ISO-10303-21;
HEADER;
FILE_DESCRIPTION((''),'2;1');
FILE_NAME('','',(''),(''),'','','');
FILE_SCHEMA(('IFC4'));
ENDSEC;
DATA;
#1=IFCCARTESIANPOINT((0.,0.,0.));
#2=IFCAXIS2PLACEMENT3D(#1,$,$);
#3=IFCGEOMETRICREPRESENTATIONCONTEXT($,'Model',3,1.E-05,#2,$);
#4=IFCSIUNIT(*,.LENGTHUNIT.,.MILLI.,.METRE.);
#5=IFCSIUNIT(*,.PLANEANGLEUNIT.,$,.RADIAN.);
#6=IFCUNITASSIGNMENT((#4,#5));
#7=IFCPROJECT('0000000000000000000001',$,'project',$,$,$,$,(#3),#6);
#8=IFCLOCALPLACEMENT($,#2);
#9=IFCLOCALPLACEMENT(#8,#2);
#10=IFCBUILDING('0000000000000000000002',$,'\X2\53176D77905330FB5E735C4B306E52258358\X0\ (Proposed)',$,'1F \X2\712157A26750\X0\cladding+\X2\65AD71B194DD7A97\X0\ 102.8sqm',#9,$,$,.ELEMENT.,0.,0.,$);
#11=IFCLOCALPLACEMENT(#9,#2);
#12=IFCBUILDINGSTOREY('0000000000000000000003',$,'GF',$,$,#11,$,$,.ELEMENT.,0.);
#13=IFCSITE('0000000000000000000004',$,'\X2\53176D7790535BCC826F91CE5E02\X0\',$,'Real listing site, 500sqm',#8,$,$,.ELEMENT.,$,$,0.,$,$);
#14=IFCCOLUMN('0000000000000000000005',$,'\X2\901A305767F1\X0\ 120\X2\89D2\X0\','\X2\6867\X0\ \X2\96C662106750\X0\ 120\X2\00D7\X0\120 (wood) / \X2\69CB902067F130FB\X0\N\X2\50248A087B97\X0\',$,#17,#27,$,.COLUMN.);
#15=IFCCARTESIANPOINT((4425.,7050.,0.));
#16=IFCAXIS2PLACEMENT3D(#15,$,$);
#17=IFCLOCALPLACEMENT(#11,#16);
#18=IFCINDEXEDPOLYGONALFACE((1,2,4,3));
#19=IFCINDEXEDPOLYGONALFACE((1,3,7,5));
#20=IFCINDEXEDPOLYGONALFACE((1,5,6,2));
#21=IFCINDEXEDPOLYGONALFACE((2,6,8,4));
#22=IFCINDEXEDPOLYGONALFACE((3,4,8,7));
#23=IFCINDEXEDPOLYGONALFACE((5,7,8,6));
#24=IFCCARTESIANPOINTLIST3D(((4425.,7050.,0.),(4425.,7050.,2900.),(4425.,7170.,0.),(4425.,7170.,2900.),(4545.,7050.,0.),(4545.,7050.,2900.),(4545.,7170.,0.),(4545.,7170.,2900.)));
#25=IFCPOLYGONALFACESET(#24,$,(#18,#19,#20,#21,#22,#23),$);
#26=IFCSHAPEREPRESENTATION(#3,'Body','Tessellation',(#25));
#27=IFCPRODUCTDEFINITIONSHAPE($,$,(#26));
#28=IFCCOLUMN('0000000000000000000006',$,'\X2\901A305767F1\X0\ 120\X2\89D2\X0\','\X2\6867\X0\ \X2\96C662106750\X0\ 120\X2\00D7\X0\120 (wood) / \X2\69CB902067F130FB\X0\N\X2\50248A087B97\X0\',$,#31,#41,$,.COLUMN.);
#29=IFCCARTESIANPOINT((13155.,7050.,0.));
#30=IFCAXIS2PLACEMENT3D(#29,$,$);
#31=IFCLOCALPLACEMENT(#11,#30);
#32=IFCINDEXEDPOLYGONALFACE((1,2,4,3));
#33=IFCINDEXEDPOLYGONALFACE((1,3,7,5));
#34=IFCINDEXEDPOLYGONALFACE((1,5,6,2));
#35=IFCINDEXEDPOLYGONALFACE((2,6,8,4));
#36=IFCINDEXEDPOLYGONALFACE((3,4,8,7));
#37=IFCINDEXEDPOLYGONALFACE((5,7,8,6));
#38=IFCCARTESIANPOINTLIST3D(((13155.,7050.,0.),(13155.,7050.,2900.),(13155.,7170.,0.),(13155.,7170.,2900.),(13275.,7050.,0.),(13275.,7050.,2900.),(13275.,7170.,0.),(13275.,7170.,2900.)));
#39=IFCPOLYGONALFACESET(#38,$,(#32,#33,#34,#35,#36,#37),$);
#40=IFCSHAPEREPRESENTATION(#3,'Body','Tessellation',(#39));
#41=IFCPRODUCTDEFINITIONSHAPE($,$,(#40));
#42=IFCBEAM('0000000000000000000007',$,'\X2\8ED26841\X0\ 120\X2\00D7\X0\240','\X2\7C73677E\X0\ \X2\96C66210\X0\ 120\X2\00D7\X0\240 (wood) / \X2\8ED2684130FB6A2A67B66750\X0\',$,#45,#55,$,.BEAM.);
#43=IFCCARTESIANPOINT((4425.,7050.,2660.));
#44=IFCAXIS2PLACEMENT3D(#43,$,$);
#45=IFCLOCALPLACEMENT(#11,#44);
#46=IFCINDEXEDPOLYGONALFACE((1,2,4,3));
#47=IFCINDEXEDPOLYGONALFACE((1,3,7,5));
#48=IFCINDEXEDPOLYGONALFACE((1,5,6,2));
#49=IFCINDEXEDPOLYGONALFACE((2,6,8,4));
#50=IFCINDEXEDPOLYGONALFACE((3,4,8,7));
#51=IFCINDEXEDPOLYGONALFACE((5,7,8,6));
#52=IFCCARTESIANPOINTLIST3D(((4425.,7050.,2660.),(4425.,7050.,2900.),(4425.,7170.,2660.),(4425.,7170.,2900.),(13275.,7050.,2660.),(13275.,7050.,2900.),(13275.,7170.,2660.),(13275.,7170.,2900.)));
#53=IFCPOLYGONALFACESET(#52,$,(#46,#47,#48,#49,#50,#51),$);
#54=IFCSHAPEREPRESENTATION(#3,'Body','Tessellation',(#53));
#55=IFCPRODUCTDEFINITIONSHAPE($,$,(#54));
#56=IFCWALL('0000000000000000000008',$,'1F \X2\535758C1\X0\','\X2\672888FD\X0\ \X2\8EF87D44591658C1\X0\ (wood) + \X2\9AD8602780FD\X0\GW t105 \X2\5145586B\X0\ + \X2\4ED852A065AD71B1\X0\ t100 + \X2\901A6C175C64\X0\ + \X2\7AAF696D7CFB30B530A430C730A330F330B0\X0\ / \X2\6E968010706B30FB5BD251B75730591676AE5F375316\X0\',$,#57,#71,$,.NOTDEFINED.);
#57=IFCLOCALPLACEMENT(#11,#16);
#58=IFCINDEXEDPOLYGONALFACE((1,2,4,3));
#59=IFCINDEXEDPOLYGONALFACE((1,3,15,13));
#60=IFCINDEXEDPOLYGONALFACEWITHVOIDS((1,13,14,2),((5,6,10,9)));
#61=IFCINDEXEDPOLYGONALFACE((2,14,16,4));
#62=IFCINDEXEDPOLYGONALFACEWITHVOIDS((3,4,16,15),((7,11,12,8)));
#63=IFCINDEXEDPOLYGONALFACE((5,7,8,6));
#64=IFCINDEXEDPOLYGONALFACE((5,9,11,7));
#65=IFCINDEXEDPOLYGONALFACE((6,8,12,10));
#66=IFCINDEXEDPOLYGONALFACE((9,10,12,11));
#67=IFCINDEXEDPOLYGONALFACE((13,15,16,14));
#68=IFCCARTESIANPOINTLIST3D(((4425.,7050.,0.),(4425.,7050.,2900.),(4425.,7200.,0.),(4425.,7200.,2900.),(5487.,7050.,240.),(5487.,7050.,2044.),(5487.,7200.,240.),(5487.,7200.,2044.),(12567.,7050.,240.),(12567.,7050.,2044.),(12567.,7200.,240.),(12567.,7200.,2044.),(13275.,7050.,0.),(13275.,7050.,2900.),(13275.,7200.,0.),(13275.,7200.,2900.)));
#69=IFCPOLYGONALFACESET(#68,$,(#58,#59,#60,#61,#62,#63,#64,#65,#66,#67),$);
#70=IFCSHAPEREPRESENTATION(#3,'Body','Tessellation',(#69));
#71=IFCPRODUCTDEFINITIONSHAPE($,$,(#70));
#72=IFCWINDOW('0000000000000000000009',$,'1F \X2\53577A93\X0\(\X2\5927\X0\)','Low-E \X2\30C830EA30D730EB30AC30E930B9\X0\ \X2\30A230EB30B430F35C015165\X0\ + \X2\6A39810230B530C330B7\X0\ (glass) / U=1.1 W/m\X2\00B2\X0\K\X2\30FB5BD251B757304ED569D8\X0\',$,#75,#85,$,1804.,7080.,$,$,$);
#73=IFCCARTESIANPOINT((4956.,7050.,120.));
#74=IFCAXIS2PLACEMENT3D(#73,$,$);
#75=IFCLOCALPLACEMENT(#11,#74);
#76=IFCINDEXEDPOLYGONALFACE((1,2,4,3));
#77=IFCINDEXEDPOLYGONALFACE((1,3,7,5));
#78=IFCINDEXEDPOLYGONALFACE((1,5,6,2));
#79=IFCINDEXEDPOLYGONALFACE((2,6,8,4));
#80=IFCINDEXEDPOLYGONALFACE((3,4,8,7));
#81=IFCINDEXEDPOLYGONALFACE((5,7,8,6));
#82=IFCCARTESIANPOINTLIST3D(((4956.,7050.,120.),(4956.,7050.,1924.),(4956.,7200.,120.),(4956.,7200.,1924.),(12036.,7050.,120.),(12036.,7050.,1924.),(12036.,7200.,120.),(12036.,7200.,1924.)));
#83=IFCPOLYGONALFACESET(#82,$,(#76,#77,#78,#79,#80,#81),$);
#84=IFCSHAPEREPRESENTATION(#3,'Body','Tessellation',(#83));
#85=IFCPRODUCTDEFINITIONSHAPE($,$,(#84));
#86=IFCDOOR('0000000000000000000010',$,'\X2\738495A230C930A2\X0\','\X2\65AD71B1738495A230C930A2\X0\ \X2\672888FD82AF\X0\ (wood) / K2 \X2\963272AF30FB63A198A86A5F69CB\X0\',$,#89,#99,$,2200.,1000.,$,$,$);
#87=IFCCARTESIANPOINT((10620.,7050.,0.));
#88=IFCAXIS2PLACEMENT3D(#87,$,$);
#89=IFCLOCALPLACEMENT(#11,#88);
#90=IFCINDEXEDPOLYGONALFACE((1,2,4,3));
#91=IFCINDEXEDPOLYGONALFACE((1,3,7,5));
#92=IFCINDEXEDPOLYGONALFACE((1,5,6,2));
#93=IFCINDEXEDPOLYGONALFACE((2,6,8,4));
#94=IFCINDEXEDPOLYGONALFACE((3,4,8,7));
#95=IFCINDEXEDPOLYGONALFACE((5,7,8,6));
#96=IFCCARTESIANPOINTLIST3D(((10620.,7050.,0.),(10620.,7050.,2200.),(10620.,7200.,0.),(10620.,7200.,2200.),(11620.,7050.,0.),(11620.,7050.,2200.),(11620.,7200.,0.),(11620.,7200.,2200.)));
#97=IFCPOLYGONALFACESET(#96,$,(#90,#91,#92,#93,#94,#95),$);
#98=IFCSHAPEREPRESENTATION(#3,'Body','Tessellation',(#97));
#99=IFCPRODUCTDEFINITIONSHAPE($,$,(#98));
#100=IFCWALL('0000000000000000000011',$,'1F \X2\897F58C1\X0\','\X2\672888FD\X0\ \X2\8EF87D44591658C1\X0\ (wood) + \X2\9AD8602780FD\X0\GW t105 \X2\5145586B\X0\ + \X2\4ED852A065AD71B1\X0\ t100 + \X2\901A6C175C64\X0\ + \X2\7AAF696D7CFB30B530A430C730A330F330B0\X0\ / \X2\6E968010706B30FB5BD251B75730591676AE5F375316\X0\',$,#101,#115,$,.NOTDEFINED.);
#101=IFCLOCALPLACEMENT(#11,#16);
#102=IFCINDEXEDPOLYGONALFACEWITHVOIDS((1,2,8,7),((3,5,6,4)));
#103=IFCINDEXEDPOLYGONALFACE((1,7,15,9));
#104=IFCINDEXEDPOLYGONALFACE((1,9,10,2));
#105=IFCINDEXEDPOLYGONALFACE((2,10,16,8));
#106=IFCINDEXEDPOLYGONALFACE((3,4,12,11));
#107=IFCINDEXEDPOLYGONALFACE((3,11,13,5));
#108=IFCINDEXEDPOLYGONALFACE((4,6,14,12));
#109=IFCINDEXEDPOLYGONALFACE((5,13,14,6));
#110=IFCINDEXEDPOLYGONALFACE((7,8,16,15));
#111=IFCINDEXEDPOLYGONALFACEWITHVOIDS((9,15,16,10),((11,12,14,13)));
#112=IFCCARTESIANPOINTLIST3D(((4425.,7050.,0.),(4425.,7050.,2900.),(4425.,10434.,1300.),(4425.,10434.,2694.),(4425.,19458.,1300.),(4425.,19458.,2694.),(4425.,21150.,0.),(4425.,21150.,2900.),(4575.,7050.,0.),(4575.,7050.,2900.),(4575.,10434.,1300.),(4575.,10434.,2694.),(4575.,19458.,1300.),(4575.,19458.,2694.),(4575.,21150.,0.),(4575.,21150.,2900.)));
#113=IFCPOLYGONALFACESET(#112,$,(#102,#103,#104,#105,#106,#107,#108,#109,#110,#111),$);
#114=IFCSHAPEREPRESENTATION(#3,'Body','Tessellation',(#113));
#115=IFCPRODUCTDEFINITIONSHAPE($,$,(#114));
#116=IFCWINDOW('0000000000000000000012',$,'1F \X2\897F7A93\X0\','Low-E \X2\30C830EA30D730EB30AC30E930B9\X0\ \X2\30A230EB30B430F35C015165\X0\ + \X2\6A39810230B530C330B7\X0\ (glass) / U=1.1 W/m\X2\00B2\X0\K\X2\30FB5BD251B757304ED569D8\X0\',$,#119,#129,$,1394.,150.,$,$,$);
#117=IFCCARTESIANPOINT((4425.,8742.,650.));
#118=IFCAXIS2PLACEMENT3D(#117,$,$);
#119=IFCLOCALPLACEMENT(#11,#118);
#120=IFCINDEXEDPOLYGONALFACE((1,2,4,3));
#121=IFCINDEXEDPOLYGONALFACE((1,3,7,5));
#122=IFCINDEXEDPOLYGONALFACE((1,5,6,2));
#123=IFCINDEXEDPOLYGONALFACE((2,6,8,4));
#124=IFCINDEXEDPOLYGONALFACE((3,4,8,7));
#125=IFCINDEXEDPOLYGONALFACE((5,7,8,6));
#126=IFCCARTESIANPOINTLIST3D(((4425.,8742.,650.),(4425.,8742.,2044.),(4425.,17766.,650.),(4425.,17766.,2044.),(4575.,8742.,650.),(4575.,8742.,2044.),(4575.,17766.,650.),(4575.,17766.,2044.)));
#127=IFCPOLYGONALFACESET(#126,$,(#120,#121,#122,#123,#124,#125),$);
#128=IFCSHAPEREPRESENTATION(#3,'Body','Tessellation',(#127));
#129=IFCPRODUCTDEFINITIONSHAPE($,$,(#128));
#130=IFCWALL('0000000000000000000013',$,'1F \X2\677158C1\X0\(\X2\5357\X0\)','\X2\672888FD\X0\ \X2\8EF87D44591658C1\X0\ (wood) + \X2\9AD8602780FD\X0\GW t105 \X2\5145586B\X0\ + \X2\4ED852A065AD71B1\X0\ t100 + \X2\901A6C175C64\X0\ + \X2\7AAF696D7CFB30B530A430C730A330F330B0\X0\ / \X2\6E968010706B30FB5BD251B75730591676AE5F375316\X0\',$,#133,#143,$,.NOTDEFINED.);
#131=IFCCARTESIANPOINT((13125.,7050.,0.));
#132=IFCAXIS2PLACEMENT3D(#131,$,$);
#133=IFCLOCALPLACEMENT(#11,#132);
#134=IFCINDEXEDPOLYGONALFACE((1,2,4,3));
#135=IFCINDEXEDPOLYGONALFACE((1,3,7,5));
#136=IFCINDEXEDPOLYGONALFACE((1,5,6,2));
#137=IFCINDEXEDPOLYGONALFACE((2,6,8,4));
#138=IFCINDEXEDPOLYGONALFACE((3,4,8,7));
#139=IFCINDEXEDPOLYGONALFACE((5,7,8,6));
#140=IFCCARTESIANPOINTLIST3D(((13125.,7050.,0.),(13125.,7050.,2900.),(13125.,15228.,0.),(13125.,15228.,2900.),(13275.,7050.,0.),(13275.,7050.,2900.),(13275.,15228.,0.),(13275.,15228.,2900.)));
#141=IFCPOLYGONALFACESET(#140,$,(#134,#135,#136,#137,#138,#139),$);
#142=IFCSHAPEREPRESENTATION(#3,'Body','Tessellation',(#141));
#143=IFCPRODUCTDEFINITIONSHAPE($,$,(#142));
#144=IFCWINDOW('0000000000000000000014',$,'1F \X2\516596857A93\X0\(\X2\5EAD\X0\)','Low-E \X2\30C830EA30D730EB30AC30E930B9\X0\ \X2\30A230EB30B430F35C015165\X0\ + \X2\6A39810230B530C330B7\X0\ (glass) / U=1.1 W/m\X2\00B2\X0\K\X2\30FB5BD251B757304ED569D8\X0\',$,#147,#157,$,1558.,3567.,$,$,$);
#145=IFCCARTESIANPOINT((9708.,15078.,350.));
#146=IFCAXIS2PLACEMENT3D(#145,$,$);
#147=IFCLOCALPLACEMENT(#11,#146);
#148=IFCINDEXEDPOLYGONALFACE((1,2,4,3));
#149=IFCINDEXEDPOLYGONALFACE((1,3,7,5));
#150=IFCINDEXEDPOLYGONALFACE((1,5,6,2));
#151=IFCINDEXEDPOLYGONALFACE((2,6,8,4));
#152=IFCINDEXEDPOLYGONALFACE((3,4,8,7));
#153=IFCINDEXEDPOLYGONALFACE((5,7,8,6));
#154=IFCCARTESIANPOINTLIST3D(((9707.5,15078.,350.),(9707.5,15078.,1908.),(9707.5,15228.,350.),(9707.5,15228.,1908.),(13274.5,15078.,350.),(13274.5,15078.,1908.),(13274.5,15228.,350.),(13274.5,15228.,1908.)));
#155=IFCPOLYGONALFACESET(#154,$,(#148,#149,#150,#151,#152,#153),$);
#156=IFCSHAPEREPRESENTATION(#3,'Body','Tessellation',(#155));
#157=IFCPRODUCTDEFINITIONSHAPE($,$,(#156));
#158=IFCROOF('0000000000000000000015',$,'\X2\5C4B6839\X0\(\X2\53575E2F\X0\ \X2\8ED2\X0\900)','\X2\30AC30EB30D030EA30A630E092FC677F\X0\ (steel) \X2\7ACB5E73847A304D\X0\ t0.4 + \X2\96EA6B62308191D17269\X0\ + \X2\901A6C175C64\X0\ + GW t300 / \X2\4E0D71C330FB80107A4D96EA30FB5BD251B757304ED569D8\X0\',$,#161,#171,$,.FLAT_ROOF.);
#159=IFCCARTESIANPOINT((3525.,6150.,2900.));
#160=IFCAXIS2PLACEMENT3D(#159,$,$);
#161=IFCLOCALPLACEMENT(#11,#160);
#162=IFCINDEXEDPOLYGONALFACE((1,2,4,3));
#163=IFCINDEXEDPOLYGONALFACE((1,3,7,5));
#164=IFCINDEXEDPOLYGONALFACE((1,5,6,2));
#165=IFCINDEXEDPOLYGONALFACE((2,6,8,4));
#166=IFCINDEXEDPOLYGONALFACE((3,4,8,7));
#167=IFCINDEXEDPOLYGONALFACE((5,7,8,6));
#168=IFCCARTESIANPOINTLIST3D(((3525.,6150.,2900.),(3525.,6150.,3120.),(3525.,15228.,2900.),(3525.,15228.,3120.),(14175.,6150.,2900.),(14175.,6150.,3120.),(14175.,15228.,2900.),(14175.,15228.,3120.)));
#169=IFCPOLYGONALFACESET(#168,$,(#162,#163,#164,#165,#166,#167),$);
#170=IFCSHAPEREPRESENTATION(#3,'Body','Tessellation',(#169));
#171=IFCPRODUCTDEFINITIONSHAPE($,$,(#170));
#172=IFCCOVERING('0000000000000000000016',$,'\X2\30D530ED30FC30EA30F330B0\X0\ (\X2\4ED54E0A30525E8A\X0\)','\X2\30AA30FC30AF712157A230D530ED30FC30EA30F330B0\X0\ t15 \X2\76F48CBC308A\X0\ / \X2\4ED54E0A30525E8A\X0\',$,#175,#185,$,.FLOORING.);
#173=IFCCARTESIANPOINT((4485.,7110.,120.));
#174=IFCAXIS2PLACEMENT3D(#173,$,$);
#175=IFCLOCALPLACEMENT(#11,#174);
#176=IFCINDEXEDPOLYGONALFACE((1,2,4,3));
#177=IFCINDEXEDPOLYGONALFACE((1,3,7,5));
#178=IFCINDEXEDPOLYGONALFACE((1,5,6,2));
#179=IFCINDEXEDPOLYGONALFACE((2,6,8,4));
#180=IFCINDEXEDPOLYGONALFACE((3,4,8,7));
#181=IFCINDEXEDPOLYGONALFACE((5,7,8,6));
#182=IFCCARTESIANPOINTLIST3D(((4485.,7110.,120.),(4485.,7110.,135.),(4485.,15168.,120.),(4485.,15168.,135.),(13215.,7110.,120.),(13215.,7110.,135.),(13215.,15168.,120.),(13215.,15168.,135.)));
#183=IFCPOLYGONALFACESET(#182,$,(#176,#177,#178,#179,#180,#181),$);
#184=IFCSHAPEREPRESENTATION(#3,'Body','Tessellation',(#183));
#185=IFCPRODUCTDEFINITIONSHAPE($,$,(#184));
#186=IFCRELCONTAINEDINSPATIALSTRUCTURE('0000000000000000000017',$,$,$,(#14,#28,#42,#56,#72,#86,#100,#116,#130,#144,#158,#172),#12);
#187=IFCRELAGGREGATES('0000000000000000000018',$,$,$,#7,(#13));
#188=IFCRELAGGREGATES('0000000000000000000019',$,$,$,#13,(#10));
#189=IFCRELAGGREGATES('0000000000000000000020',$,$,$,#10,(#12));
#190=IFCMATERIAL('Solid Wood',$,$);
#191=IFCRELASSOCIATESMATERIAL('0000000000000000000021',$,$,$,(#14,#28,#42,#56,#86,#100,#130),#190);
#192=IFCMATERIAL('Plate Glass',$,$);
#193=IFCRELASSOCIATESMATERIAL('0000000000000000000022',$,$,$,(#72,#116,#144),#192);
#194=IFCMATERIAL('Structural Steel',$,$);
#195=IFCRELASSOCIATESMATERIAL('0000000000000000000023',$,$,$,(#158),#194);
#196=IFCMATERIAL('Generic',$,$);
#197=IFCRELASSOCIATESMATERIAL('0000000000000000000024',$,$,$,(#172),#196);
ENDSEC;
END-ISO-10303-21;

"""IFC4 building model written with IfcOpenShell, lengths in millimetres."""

from ifc_helpers import new_model, si_unit, frame, frame_2d, origin, place, context, project, spatial, rectangle, extrude, material, element, fill, save


model = new_model("IFC4")

# Units and contexts
model_context = context("Model", 3, precision=1e-05, world=origin())
ifc_project = project(units=[si_unit("LENGTHUNIT", "METRE", prefix="MILLI"), si_unit("PLANEANGLEUNIT", "RADIAN")], contexts=[model_context])

# Site, building, storey
site_placement = place(None, origin())
site = spatial("IfcSite", under=ifc_project, at=site_placement, Name="北海道富良野市", ObjectType="Real listing site, 500sqm", CompositionType="ELEMENT", RefElevation=0.0)
building_placement = place(site_placement, origin())
building = spatial("IfcBuilding", under=site, at=building_placement, Name="北海道・平屋の別荘 (Proposed)", ObjectType="1F 無垢材cladding+断熱铝窗 102.8sqm", CompositionType="ELEMENT", ElevationOfRefHeight=0.0, ElevationOfTerrain=0.0)
storey_placement = place(building_placement, origin())
storey = spatial("IfcBuildingStorey", under=building, at=storey_placement, Name="GF", CompositionType="ELEMENT", Elevation=0.0)

# Columns
ifc_material_1 = material(Name="Solid Wood")
column_1_placement = place(storey_placement, frame((4425.0, 7050.0, 0.0)))
element("IfcColumn", 1, at=column_1_placement, inside=storey, material=ifc_material_1, Name="通し柱 120角", Description="桧 集成材 120×120 (wood) / 構造柱・N値計算", PredefinedType="COLUMN", context=model_context, shape_type="SweptSolid", body=[
    extrude(rectangle(XDim=120.0, YDim=120.0, at=frame_2d((60.0, 60.0))), frame((4425.0, 7050.0, 0.0)), (0.0, 0.0, 1.0), 2900.0),
])
column_2_placement = place(storey_placement, frame((13155.0, 7050.0, 0.0)))
element("IfcColumn", 2, at=column_2_placement, inside=storey, material=ifc_material_1, Name="通し柱 120角", Description="桧 集成材 120×120 (wood) / 構造柱・N値計算", PredefinedType="COLUMN", context=model_context, shape_type="SweptSolid", body=[
    extrude(rectangle(XDim=120.0, YDim=120.0, at=frame_2d((60.0, 60.0))), frame((13155.0, 7050.0, 0.0)), (0.0, 0.0, 1.0), 2900.0),
])

# Beam
beam_1_placement = place(storey_placement, frame((4425.0, 7050.0, 2660.0)))
element("IfcBeam", 3, at=beam_1_placement, inside=storey, material=ifc_material_1, Name="軒桁 120×240", Description="米松 集成 120×240 (wood) / 軒桁・横架材", PredefinedType="BEAM", context=model_context, shape_type="SweptSolid", body=[
    extrude(rectangle(XDim=8850.0, YDim=120.0, at=frame_2d((4425.0, 60.0))), frame((4425.0, 7050.0, 2660.0)), (0.0, 0.0, 1.0), 240.0),
])

# Wall, openings, window, door
wall_1_placement = place(storey_placement, frame((4425.0, 7050.0, 0.0)))
wall_1 = element("IfcWall", 4, at=wall_1_placement, inside=storey, material=ifc_material_1, Name="1F 南壁", Description="木製 軸組外壁 (wood) + 高性能GW t105 充填 + 付加断熱 t100 + 通気層 + 窯業系サイディング / 準耐火・寒冷地外皮強化", PredefinedType="NOTDEFINED", context=model_context, shape_type="SweptSolid", body=[
    extrude(rectangle(XDim=8850.0, YDim=150.0, at=frame_2d((4425.0, 75.0))), frame((4425.0, 7050.0, 0.0)), (0.0, 0.0, 1.0), 2900.0),
])
opening_1_placement = place(storey_placement, frame((4956.0, 7050.0, 120.0)))
opening_1 = element("IfcOpeningElement", 5, at=opening_1_placement, cuts=wall_1, PredefinedType="NOTDEFINED", context=model_context, shape_type="SweptSolid", body=[
    extrude(rectangle(XDim=7080.0, YDim=150.0, at=frame_2d((3540.0, 75.0))), frame((4956.0, 7050.0, 120.0)), (0.0, 0.0, 1.0), 1804.0),
])
opening_2_placement = place(storey_placement, frame((10620.0, 7050.0, 0.0)))
opening_2 = element("IfcOpeningElement", 6, at=opening_2_placement, cuts=wall_1, PredefinedType="NOTDEFINED", context=model_context, shape_type="SweptSolid", body=[
    extrude(rectangle(XDim=1000.0, YDim=150.0, at=frame_2d((500.0, 75.0))), frame((10620.0, 7050.0, 0.0)), (0.0, 0.0, 1.0), 2200.0),
])
ifc_material_2 = material(Name="Plate Glass")
window_1_placement = place(storey_placement, frame((4956.0, 7050.0, 120.0)))
window_1 = element("IfcWindow", 7, at=window_1_placement, inside=storey, material=ifc_material_2, Name="1F 南窓(大)", Description="Low-E トリプルガラス アルゴン封入 + 樹脂サッシ (glass) / U=1.1 W/m²K・寒冷地仕様", OverallHeight=1804.0, OverallWidth=7080.0, context=model_context, shape_type="SweptSolid", body=[
    extrude(rectangle(XDim=7080.0, YDim=150.0, at=frame_2d((3540.0, 75.0))), frame((4956.0, 7050.0, 120.0)), (0.0, 0.0, 1.0), 1804.0),
])
fill(opening_1, window_1)
door_1_placement = place(storey_placement, frame((10620.0, 7050.0, 0.0)))
door_1 = element("IfcDoor", 8, at=door_1_placement, inside=storey, material=ifc_material_1, Name="玄関ドア", Description="断熱玄関ドア 木製芯 (wood) / K2 防犯・採風機構", OverallHeight=2200.0, OverallWidth=1000.0, context=model_context, shape_type="SweptSolid", body=[
    extrude(rectangle(XDim=1000.0, YDim=150.0, at=frame_2d((500.0, 75.0))), frame((10620.0, 7050.0, 0.0)), (0.0, 0.0, 1.0), 2200.0),
])
fill(opening_2, door_1)

# Walls, openings, windows
wall_2_placement = place(storey_placement, frame((4425.0, 7050.0, 0.0)))
wall_2 = element("IfcWall", 9, at=wall_2_placement, inside=storey, material=ifc_material_1, Name="1F 西壁", Description="木製 軸組外壁 (wood) + 高性能GW t105 充填 + 付加断熱 t100 + 通気層 + 窯業系サイディング / 準耐火・寒冷地外皮強化", PredefinedType="NOTDEFINED", context=model_context, shape_type="SweptSolid", body=[
    extrude(rectangle(XDim=150.0, YDim=14100.0, at=frame_2d((75.0, 7050.0))), frame((4425.0, 7050.0, 0.0)), (0.0, 0.0, 1.0), 2900.0),
])
opening_3_placement = place(storey_placement, frame((4425.0, 8742.0, 650.0)))
opening_3 = element("IfcOpeningElement", 10, at=opening_3_placement, cuts=wall_2, PredefinedType="NOTDEFINED", context=model_context, shape_type="SweptSolid", body=[
    extrude(rectangle(XDim=150.0, YDim=9024.0, at=frame_2d((75.0, 4512.0))), frame((4425.0, 8742.0, 650.0)), (0.0, 0.0, 1.0), 1394.0),
])
window_2_placement = place(storey_placement, frame((4425.0, 8742.0, 650.0)))
window_2 = element("IfcWindow", 11, at=window_2_placement, inside=storey, material=ifc_material_2, Name="1F 西窓", Description="Low-E トリプルガラス アルゴン封入 + 樹脂サッシ (glass) / U=1.1 W/m²K・寒冷地仕様", OverallHeight=1394.0, OverallWidth=150.0, context=model_context, shape_type="SweptSolid", body=[
    extrude(rectangle(XDim=150.0, YDim=9024.0, at=frame_2d((75.0, 4512.0))), frame((4425.0, 8742.0, 650.0)), (0.0, 0.0, 1.0), 1394.0),
])
fill(opening_3, window_2)
wall_3_placement = place(storey_placement, frame((13125.0, 7050.0, 0.0)))
wall_3 = element("IfcWall", 12, at=wall_3_placement, inside=storey, material=ifc_material_1, Name="1F 東壁(南)", Description="木製 軸組外壁 (wood) + 高性能GW t105 充填 + 付加断熱 t100 + 通気層 + 窯業系サイディング / 準耐火・寒冷地外皮強化", PredefinedType="NOTDEFINED", context=model_context, shape_type="SweptSolid", body=[
    extrude(rectangle(XDim=150.0, YDim=8178.0, at=frame_2d((75.0, 4089.0))), frame((13125.0, 7050.0, 0.0)), (0.0, 0.0, 1.0), 2900.0),
])
opening_4_placement = place(storey_placement, frame((9708.0, 15078.0, 350.0)))
opening_4 = element("IfcOpeningElement", 13, at=opening_4_placement, cuts=wall_3, PredefinedType="NOTDEFINED", context=model_context, shape_type="SweptSolid", body=[
    extrude(rectangle(XDim=3567.0, YDim=150.0, at=frame_2d((1783.0, 75.0))), frame((9708.0, 15078.0, 350.0)), (0.0, 0.0, 1.0), 1558.0),
])
window_3_placement = place(storey_placement, frame((9708.0, 15078.0, 350.0)))
window_3 = element("IfcWindow", 14, at=window_3_placement, inside=storey, material=ifc_material_2, Name="1F 入隅窓(庭)", Description="Low-E トリプルガラス アルゴン封入 + 樹脂サッシ (glass) / U=1.1 W/m²K・寒冷地仕様", OverallHeight=1558.0, OverallWidth=3567.0, context=model_context, shape_type="SweptSolid", body=[
    extrude(rectangle(XDim=3567.0, YDim=150.0, at=frame_2d((1783.0, 75.0))), frame((9708.0, 15078.0, 350.0)), (0.0, 0.0, 1.0), 1558.0),
])
fill(opening_4, window_3)

# Roof
ifc_material_3 = material(Name="Structural Steel")
roof_placement = place(storey_placement, frame((3525.0, 6150.0, 2900.0)))
element("IfcRoof", 15, at=roof_placement, inside=storey, material=ifc_material_3, Name="屋根(南帯 軒900)", Description="ガルバリウム鋼板 (steel) 立平葺き t0.4 + 雪止め金物 + 通気層 + GW t300 / 不燃・耐積雪・寒冷地仕様", PredefinedType="FLAT_ROOF", context=model_context, shape_type="SweptSolid", body=[
    extrude(rectangle(XDim=10650.0, YDim=9078.0, at=frame_2d((5325.0, 4539.0))), frame((3525.0, 6150.0, 2900.0)), (0.0, 0.0, 1.0), 220.0),
])

# Covering
ifc_material_4 = material(Name="Generic")
covering_1_placement = place(storey_placement, frame((4485.0, 7110.0, 120.0)))
element("IfcCovering", 16, at=covering_1_placement, inside=storey, material=ifc_material_4, Name="フローリング (仕上げ床)", Description="オーク無垢フローリング t15 直貼り / 仕上げ床", PredefinedType="FLOORING", context=model_context, shape_type="SweptSolid", body=[
    extrude(rectangle(XDim=8730.0, YDim=8058.0, at=frame_2d((4365.0, 4029.0))), frame((4485.0, 7110.0, 120.0)), (0.0, 0.0, 1.0), 15.0),
])

save(model, "model.ifc")
